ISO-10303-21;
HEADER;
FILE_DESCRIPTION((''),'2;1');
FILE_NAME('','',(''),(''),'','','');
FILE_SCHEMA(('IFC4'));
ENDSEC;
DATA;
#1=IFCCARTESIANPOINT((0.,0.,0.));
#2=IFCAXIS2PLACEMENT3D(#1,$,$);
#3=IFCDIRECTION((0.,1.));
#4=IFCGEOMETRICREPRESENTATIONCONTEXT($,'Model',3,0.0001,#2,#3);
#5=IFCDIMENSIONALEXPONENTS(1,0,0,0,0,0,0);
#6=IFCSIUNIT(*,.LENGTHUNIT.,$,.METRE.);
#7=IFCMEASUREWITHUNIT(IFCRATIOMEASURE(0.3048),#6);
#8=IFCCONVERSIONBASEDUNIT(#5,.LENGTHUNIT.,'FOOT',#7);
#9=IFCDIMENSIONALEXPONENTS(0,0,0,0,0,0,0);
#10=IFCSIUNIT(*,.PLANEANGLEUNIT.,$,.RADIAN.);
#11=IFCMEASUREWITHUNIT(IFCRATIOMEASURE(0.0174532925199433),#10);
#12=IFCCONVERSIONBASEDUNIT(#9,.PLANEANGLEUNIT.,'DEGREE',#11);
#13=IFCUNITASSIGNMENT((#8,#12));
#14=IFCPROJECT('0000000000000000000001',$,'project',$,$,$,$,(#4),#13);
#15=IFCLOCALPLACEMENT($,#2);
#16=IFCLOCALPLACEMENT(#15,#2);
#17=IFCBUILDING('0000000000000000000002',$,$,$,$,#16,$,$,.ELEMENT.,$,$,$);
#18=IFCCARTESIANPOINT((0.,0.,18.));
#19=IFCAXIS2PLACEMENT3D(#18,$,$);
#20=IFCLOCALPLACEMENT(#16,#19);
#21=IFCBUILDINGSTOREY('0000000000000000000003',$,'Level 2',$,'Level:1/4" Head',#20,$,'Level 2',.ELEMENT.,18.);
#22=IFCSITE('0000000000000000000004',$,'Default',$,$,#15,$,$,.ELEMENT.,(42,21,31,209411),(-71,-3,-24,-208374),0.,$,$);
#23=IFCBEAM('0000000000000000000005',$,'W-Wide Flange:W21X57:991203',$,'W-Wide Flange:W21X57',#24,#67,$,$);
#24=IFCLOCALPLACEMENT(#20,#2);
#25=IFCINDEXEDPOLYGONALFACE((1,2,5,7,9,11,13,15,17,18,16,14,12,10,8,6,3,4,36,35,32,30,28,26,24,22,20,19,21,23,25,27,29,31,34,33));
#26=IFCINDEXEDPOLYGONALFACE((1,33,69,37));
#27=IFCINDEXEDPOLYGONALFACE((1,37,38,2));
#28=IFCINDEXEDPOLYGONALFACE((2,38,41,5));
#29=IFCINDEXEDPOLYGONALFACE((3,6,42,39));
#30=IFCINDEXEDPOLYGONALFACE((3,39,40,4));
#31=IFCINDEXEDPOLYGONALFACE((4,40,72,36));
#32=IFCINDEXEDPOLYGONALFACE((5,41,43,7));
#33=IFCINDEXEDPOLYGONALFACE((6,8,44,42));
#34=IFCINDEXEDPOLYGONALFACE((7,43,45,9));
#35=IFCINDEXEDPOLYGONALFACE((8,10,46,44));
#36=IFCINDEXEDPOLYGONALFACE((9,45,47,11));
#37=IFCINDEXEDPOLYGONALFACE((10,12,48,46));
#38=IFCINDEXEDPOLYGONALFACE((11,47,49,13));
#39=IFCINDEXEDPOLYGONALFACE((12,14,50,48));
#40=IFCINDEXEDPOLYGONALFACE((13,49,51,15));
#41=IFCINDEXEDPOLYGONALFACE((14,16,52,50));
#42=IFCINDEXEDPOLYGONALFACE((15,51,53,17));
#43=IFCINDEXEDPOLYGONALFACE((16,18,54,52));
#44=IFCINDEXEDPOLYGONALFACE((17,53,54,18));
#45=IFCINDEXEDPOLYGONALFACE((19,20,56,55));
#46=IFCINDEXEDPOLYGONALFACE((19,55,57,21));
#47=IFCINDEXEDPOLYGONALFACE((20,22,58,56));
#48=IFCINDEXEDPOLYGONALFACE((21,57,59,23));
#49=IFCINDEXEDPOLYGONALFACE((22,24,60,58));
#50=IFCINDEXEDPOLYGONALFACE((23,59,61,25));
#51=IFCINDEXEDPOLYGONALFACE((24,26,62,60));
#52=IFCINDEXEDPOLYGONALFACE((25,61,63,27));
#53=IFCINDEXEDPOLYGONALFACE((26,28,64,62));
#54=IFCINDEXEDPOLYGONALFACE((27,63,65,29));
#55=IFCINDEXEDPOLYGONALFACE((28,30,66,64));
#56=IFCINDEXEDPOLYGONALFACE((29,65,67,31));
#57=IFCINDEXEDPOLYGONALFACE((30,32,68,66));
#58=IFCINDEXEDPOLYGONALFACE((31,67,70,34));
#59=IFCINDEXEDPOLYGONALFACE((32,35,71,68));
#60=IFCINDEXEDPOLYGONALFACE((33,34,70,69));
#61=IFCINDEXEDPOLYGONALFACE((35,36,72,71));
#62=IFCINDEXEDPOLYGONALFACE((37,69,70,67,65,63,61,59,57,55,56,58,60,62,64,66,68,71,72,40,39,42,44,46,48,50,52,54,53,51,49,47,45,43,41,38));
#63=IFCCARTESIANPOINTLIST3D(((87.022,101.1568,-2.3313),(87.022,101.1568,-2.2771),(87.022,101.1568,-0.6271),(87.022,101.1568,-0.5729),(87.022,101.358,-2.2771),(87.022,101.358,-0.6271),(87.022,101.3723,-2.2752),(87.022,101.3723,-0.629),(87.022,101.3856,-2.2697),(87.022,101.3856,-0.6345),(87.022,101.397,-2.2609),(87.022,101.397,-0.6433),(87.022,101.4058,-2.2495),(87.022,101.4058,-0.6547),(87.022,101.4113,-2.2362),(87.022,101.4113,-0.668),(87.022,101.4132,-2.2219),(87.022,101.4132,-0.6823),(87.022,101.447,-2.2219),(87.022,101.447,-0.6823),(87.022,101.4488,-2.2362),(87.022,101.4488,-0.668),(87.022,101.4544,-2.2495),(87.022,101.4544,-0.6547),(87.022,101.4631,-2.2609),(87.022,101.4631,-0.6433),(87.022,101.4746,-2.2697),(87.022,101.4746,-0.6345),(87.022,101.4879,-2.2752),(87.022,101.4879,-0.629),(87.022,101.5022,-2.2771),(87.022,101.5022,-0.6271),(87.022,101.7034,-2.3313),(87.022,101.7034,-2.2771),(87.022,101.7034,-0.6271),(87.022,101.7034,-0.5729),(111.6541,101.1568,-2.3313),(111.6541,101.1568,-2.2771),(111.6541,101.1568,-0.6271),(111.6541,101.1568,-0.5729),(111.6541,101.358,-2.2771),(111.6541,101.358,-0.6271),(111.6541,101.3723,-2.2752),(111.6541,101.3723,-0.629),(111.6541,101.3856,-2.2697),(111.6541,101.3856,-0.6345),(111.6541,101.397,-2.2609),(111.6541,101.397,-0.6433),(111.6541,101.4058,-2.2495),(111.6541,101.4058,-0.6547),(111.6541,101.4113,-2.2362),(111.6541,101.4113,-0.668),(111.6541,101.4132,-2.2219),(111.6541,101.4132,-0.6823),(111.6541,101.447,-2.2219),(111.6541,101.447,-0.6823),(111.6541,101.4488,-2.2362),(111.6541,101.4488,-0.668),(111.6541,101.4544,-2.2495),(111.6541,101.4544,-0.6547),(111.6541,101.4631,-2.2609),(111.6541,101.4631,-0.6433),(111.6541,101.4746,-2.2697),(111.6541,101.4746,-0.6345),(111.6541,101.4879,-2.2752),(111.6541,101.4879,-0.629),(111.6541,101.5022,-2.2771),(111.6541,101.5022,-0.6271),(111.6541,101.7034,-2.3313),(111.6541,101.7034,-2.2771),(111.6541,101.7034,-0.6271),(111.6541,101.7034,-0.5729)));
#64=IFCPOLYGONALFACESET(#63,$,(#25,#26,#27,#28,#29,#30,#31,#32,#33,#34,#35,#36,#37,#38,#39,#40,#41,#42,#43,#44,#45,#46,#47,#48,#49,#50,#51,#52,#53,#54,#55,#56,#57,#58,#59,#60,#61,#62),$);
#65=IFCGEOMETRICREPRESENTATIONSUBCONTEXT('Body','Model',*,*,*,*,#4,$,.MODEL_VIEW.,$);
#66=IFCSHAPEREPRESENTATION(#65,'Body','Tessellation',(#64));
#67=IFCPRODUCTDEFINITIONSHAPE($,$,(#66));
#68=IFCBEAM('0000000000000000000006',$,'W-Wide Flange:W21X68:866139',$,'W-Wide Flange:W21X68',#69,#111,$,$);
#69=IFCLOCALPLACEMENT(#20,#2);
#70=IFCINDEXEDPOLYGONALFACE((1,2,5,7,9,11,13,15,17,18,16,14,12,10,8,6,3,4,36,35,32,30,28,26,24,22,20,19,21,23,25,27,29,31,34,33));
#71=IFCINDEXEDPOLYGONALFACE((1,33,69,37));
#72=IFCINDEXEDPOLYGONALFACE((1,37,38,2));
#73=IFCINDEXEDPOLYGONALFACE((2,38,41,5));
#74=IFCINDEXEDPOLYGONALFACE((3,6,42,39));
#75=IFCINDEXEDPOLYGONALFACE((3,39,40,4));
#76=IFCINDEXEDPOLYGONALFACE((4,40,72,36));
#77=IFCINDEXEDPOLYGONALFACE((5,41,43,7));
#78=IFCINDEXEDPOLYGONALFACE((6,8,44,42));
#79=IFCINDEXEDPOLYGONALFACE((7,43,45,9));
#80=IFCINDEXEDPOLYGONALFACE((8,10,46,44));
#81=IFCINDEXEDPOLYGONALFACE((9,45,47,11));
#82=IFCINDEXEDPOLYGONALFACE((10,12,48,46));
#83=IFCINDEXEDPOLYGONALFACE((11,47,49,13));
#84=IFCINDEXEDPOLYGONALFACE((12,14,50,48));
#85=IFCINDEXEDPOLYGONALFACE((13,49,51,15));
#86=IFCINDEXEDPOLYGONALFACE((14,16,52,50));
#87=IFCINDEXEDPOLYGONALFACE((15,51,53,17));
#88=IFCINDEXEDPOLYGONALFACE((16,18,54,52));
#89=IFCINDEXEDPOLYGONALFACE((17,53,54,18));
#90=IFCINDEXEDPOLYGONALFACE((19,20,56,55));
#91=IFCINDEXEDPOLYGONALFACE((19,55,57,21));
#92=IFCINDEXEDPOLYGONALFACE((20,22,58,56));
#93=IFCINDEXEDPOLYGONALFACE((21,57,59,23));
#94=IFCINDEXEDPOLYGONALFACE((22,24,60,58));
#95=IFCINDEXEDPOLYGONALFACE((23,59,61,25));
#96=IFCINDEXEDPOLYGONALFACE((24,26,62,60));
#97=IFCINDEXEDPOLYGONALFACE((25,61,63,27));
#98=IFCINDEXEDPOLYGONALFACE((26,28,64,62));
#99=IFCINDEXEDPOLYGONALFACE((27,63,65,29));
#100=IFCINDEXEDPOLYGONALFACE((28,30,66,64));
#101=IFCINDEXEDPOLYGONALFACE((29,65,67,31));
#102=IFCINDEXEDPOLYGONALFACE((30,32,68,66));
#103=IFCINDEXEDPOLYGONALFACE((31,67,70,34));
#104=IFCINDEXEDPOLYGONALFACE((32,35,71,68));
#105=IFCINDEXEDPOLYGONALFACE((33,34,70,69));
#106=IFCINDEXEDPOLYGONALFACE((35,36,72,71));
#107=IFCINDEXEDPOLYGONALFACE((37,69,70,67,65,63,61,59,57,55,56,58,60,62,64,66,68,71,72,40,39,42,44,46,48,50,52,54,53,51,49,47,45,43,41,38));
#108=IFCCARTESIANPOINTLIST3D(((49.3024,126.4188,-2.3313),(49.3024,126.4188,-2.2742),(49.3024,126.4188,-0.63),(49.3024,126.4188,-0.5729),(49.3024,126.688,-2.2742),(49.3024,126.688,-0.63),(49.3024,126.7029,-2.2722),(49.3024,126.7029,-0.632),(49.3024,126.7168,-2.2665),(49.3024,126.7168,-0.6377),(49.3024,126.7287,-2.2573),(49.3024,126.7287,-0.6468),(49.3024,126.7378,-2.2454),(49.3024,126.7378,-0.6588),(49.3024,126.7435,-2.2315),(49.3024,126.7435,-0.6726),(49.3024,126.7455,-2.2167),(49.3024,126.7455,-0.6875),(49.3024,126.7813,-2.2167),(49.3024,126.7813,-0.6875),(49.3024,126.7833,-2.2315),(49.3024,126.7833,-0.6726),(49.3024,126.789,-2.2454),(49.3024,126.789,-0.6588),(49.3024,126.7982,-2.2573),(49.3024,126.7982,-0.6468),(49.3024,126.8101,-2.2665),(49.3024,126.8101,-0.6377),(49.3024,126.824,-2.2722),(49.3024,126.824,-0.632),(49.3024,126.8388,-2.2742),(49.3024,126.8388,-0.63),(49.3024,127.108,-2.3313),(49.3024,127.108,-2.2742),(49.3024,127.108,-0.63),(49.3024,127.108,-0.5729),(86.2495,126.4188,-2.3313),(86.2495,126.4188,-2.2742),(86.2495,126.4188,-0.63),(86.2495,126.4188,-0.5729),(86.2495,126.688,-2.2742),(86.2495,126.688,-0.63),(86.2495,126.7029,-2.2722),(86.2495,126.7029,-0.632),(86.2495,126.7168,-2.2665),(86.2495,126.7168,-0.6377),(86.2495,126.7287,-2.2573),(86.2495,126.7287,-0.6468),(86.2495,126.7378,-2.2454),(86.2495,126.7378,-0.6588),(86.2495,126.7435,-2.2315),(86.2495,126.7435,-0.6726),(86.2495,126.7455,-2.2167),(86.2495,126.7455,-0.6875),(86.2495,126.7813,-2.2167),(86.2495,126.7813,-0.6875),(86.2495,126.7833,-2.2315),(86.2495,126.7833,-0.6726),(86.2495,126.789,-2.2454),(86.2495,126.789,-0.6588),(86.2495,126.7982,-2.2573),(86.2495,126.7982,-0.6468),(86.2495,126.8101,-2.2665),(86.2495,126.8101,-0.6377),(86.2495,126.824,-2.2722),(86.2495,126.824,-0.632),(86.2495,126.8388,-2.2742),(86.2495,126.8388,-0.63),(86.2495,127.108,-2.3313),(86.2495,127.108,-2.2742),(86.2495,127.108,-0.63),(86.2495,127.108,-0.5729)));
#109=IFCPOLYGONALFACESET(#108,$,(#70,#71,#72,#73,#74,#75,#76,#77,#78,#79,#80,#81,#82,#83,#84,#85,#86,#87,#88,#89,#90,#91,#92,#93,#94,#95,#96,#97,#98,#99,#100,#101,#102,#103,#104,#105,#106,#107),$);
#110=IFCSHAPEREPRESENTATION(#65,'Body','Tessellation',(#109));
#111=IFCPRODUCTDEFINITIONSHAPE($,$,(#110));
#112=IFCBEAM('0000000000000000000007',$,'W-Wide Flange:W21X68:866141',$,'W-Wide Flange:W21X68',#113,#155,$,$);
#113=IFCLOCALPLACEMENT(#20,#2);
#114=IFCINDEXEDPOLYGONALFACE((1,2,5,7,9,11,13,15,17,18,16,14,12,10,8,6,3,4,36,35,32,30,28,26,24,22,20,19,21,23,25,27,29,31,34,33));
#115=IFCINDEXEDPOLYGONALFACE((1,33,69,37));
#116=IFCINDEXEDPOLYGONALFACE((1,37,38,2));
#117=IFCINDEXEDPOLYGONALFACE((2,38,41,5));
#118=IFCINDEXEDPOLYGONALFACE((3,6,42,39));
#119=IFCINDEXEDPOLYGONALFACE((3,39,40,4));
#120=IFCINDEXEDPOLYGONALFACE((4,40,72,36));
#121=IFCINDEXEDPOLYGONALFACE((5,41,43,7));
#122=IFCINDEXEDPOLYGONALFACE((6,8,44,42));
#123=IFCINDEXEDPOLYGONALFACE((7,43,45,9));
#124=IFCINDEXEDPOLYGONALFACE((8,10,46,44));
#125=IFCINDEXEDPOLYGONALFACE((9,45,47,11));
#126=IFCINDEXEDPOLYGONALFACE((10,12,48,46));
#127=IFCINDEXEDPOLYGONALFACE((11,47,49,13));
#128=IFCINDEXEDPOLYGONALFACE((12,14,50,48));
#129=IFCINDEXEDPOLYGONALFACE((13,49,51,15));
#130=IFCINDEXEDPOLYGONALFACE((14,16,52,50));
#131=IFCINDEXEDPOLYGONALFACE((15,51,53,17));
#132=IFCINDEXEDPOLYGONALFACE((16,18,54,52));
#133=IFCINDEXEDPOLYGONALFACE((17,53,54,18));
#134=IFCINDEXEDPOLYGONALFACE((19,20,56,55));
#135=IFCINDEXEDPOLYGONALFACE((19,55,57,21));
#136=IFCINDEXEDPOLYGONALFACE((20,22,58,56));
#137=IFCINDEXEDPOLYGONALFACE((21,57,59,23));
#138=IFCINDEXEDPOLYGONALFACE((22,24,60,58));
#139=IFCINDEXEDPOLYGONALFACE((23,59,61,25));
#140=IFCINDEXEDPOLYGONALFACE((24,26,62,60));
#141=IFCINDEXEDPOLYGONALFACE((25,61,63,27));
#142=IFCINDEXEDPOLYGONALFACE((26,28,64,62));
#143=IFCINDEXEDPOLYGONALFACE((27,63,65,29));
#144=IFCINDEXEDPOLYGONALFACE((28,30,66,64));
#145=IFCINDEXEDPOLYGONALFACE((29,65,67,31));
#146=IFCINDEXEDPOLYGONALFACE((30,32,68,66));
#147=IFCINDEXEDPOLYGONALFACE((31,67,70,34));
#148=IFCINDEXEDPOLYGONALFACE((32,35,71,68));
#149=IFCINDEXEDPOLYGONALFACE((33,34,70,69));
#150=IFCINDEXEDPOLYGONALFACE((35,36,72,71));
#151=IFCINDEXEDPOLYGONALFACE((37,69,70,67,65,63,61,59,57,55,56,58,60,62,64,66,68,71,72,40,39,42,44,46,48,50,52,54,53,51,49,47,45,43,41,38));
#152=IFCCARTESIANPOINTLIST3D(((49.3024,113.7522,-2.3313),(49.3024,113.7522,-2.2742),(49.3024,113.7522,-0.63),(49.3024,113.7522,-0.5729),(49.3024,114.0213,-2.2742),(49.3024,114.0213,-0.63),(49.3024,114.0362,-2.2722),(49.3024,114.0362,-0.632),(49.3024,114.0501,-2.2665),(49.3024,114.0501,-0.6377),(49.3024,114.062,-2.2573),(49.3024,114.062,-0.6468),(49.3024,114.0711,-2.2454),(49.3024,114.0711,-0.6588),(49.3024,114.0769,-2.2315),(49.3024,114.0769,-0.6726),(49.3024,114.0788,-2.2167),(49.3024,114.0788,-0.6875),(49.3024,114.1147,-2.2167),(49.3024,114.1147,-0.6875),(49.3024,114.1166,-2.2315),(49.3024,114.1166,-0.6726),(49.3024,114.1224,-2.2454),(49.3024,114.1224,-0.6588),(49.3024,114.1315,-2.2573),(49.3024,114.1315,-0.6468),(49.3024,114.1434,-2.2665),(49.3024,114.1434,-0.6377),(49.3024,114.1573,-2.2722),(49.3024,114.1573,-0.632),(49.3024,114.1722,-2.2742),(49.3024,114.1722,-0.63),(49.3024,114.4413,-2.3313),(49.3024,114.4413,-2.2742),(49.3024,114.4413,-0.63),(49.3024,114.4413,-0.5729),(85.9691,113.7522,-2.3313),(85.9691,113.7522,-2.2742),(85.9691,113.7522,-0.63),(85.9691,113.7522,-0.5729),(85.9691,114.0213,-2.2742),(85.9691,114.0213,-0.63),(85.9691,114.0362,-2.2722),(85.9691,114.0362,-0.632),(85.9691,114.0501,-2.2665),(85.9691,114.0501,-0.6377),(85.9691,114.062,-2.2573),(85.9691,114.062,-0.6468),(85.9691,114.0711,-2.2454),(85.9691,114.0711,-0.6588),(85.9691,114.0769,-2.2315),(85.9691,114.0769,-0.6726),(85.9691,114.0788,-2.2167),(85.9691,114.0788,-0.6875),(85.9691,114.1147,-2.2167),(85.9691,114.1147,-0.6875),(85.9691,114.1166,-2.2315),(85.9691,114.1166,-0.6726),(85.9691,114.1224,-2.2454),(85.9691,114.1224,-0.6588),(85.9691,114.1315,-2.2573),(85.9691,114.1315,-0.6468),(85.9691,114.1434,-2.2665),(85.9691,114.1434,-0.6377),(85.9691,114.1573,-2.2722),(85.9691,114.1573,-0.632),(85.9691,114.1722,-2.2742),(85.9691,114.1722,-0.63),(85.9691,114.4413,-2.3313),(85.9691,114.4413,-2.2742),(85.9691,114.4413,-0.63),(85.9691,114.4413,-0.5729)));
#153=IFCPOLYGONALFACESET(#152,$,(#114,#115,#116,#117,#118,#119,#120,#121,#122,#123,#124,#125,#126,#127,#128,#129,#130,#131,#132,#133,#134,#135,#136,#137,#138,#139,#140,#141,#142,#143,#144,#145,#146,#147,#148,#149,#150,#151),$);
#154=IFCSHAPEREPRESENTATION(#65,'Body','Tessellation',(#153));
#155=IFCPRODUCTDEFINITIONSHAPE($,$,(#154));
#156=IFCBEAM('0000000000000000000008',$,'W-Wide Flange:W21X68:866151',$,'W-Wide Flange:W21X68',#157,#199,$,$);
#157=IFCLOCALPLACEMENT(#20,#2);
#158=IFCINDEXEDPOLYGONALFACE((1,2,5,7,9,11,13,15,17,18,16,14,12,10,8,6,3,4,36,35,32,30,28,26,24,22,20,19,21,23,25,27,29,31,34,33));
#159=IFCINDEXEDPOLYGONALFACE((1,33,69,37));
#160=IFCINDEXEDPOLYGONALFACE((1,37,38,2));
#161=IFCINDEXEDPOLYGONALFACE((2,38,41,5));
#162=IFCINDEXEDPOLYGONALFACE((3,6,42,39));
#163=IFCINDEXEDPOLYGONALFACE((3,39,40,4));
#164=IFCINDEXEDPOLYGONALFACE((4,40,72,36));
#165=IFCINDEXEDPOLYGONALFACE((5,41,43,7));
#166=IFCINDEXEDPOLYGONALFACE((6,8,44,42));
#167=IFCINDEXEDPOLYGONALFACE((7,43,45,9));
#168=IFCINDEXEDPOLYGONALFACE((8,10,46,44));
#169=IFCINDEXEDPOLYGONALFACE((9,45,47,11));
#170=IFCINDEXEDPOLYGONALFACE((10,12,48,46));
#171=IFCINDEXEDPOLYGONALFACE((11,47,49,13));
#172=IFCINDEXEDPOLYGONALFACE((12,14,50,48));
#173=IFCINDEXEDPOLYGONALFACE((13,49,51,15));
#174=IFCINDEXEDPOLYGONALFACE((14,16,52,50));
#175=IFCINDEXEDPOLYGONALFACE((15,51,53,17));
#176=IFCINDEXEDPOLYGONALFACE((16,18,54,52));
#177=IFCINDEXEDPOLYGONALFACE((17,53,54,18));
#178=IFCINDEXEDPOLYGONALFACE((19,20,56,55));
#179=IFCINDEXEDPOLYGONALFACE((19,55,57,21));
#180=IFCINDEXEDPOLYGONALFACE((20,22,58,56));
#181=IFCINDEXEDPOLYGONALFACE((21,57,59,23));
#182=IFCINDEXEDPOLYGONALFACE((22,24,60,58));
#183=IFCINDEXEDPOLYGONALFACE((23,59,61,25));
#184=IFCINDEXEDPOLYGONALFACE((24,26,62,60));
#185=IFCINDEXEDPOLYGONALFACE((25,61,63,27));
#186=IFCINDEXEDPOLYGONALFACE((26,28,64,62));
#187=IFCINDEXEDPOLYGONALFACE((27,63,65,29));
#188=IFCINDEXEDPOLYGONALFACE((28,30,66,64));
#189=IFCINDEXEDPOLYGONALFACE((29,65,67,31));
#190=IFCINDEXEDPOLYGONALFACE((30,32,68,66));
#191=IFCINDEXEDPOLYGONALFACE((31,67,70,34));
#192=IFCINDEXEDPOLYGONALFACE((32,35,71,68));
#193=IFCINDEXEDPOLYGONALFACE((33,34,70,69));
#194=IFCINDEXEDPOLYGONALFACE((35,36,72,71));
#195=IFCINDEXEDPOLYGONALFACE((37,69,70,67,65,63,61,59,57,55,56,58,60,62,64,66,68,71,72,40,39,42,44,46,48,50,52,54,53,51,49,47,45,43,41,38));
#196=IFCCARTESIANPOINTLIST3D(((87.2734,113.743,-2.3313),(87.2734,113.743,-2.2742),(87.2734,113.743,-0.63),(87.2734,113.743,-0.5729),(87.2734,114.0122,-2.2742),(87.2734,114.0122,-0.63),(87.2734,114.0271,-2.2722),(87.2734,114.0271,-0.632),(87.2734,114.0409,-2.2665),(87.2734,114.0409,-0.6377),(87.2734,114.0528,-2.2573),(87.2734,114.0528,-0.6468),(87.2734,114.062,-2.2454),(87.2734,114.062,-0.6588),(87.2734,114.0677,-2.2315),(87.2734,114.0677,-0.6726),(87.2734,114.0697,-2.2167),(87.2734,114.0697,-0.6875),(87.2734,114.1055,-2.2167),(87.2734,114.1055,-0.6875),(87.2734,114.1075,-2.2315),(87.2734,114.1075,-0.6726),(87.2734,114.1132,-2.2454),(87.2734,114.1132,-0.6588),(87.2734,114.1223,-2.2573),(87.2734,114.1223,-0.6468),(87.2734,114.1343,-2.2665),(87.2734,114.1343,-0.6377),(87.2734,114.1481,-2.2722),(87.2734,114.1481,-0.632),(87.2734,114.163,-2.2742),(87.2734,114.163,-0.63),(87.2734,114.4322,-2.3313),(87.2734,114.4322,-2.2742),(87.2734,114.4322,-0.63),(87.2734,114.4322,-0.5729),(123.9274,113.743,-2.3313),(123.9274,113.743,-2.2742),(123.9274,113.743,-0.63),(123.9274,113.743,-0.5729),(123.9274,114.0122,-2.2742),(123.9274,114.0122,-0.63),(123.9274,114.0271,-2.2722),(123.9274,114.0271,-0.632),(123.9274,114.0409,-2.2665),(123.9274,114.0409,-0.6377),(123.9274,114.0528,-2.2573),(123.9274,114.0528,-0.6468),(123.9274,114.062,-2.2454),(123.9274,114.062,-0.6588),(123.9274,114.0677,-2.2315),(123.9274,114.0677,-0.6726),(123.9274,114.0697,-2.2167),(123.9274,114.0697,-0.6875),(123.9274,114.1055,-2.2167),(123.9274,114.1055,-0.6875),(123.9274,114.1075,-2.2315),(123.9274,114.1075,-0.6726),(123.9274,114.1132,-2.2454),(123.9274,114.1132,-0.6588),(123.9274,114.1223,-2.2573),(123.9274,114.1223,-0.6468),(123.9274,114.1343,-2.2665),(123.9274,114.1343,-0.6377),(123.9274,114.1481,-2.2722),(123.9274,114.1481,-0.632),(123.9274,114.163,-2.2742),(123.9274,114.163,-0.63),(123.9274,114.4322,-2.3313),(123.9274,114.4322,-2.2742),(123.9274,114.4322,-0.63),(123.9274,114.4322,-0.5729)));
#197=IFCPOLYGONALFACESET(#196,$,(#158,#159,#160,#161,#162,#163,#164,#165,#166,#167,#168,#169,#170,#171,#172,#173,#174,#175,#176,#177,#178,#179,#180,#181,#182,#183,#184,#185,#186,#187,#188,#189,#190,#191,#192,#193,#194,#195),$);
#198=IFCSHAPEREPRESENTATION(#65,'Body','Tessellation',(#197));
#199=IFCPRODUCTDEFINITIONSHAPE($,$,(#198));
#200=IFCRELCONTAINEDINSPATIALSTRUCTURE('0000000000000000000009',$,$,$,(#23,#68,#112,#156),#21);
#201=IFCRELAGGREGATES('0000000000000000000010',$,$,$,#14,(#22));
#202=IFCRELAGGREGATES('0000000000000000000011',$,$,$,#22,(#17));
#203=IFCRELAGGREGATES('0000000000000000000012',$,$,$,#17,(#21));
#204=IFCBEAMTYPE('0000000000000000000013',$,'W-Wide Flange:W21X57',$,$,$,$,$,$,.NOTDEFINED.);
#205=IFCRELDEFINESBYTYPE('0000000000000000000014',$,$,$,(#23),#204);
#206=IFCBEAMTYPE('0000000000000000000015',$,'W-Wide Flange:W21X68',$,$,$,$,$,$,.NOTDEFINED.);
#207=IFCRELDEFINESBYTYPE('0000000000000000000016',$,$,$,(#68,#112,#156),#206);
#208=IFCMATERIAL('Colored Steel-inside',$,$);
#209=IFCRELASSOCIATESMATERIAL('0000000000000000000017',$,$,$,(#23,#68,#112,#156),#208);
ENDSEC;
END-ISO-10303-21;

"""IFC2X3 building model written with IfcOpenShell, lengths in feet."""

from ifc_helpers import new_model, entity, si_unit, converted_unit, direction, frame, frame_2d, origin, place, context, subcontext, project, spatial, i_section, extrude, material, type_object, element, save


model = new_model("IFC2X3")

# Units and contexts
model_context = context("Model", 3, precision=0.0001, world=origin(), true_north=direction((0.0, 1.0)))
body_context = subcontext(model_context, "Body", "Model", "MODEL_VIEW")
ifc_project = project(units=[converted_unit("LENGTHUNIT", "FOOT", entity("IfcRatioMeasure", 0.3048), si_unit("LENGTHUNIT", "METRE"), dimensions=[1, 0, 0, 0, 0, 0, 0]), converted_unit("PLANEANGLEUNIT", "DEGREE", entity("IfcRatioMeasure", 0.0174532925199433), si_unit("PLANEANGLEUNIT", "RADIAN"), dimensions=[0, 0, 0, 0, 0, 0, 0])], contexts=[model_context])

# Site, building, storey
site_placement = place(None, origin())
site = spatial("IfcSite", under=ifc_project, at=site_placement, Name="Default", CompositionType="ELEMENT", RefLatitude=(42, 21, 31, 209411), RefLongitude=(-71, -3, -24, -208374), RefElevation=0.0)
building_placement = place(site_placement, origin())
building = spatial("IfcBuilding", under=site, at=building_placement, CompositionType="ELEMENT")
storey_placement = place(building_placement, frame((0.0, 0.0, 18.0)))
storey = spatial("IfcBuildingStorey", under=building, at=storey_placement, Name="Level 2", ObjectType="Level:1/4\" Head", LongName="Level 2", CompositionType="ELEMENT", Elevation=18.0)

# Shared definitions
ifc_material_1 = material(Name="Colored Steel-inside")

# Beams
beam_type_1 = type_object("IfcBeamType", Name="W-Wide Flange:W21X57", PredefinedType="NOTDEFINED")
beam_1_placement = place(storey_placement, frame((111.9887, 101.4301, 0.0), z_axis=(0.0, 0.0, 1.0), x_axis=(-1.0, 0.0, 0.0)))
element("IfcBeam", 1, at=beam_1_placement, inside=storey, type_object=beam_type_1, material=ifc_material_1, Name="W-Wide Flange:W21X57:991203", ObjectType="W-Wide Flange:W21X57", context=body_context, shape_type="SweptSolid", body=[
    extrude(i_section(OverallWidth=0.5467, OverallDepth=1.7583, WebThickness=0.0337, FlangeThickness=0.0542, FilletRadius=0.0552, at=frame_2d((0.0, 0.0), x_axis=(0.0, 1.0))), frame((0.3346, 0.0, -1.4521), z_axis=(1.0, 0.0, 0.0), x_axis=(0.0, 0.0, -1.0)), (0.0, 0.0, 1.0), 24.6321),
])
beam_type_2 = type_object("IfcBeamType", Name="W-Wide Flange:W21X68", PredefinedType="NOTDEFINED")
beam_2_placement = place(storey_placement, frame((49.0524, 126.7634, 0.0)))
element("IfcBeam", 2, at=beam_2_placement, inside=storey, type_object=beam_type_2, material=ifc_material_1, Name="W-Wide Flange:W21X68:866139", ObjectType="W-Wide Flange:W21X68", context=body_context, shape_type="SweptSolid", body=[
    extrude(i_section(OverallWidth=0.6892, OverallDepth=1.7583, WebThickness=0.0358, FlangeThickness=0.0571, FilletRadius=0.0575, at=frame_2d((0.0, 0.0), x_axis=(0.0, 1.0))), frame((0.25, 0.0, -1.4521), z_axis=(1.0, 0.0, 0.0), x_axis=(0.0, 0.0, -1.0)), (0.0, 0.0, 1.0), 36.9471),
])
beam_3_placement = place(storey_placement, frame((49.6554, 114.0968, 0.0)))
element("IfcBeam", 3, at=beam_3_placement, inside=storey, type_object=beam_type_2, material=ifc_material_1, Name="W-Wide Flange:W21X68:866141", ObjectType="W-Wide Flange:W21X68", context=body_context, shape_type="SweptSolid", body=[
    extrude(i_section(OverallWidth=0.6892, OverallDepth=1.7583, WebThickness=0.0358, FlangeThickness=0.0571, FilletRadius=0.0575, at=frame_2d((0.0, 0.0), x_axis=(0.0, 1.0))), frame((-0.3529, 0.0, -1.4521), z_axis=(1.0, 0.0, 0.0), x_axis=(0.0, 0.0, -1.0)), (0.0, 0.0, 1.0), 36.6667),
])
beam_4_placement = place(storey_placement, frame((124.6358, 114.0876, 0.0), z_axis=(0.0, 0.0, 1.0), x_axis=(-1.0, 0.0, 0.0)))
element("IfcBeam", 4, at=beam_4_placement, inside=storey, type_object=beam_type_2, material=ifc_material_1, Name="W-Wide Flange:W21X68:866151", ObjectType="W-Wide Flange:W21X68", context=body_context, shape_type="SweptSolid", body=[
    extrude(i_section(OverallWidth=0.6892, OverallDepth=1.7583, WebThickness=0.0358, FlangeThickness=0.0571, FilletRadius=0.0575, at=frame_2d((0.0, 0.0), x_axis=(0.0, 1.0))), frame((0.7083, 0.0, -1.4521), z_axis=(1.0, 0.0, 0.0), x_axis=(0.0, 0.0, -1.0)), (0.0, 0.0, 1.0), 36.6541),
])

save(model, "model.ifc")
